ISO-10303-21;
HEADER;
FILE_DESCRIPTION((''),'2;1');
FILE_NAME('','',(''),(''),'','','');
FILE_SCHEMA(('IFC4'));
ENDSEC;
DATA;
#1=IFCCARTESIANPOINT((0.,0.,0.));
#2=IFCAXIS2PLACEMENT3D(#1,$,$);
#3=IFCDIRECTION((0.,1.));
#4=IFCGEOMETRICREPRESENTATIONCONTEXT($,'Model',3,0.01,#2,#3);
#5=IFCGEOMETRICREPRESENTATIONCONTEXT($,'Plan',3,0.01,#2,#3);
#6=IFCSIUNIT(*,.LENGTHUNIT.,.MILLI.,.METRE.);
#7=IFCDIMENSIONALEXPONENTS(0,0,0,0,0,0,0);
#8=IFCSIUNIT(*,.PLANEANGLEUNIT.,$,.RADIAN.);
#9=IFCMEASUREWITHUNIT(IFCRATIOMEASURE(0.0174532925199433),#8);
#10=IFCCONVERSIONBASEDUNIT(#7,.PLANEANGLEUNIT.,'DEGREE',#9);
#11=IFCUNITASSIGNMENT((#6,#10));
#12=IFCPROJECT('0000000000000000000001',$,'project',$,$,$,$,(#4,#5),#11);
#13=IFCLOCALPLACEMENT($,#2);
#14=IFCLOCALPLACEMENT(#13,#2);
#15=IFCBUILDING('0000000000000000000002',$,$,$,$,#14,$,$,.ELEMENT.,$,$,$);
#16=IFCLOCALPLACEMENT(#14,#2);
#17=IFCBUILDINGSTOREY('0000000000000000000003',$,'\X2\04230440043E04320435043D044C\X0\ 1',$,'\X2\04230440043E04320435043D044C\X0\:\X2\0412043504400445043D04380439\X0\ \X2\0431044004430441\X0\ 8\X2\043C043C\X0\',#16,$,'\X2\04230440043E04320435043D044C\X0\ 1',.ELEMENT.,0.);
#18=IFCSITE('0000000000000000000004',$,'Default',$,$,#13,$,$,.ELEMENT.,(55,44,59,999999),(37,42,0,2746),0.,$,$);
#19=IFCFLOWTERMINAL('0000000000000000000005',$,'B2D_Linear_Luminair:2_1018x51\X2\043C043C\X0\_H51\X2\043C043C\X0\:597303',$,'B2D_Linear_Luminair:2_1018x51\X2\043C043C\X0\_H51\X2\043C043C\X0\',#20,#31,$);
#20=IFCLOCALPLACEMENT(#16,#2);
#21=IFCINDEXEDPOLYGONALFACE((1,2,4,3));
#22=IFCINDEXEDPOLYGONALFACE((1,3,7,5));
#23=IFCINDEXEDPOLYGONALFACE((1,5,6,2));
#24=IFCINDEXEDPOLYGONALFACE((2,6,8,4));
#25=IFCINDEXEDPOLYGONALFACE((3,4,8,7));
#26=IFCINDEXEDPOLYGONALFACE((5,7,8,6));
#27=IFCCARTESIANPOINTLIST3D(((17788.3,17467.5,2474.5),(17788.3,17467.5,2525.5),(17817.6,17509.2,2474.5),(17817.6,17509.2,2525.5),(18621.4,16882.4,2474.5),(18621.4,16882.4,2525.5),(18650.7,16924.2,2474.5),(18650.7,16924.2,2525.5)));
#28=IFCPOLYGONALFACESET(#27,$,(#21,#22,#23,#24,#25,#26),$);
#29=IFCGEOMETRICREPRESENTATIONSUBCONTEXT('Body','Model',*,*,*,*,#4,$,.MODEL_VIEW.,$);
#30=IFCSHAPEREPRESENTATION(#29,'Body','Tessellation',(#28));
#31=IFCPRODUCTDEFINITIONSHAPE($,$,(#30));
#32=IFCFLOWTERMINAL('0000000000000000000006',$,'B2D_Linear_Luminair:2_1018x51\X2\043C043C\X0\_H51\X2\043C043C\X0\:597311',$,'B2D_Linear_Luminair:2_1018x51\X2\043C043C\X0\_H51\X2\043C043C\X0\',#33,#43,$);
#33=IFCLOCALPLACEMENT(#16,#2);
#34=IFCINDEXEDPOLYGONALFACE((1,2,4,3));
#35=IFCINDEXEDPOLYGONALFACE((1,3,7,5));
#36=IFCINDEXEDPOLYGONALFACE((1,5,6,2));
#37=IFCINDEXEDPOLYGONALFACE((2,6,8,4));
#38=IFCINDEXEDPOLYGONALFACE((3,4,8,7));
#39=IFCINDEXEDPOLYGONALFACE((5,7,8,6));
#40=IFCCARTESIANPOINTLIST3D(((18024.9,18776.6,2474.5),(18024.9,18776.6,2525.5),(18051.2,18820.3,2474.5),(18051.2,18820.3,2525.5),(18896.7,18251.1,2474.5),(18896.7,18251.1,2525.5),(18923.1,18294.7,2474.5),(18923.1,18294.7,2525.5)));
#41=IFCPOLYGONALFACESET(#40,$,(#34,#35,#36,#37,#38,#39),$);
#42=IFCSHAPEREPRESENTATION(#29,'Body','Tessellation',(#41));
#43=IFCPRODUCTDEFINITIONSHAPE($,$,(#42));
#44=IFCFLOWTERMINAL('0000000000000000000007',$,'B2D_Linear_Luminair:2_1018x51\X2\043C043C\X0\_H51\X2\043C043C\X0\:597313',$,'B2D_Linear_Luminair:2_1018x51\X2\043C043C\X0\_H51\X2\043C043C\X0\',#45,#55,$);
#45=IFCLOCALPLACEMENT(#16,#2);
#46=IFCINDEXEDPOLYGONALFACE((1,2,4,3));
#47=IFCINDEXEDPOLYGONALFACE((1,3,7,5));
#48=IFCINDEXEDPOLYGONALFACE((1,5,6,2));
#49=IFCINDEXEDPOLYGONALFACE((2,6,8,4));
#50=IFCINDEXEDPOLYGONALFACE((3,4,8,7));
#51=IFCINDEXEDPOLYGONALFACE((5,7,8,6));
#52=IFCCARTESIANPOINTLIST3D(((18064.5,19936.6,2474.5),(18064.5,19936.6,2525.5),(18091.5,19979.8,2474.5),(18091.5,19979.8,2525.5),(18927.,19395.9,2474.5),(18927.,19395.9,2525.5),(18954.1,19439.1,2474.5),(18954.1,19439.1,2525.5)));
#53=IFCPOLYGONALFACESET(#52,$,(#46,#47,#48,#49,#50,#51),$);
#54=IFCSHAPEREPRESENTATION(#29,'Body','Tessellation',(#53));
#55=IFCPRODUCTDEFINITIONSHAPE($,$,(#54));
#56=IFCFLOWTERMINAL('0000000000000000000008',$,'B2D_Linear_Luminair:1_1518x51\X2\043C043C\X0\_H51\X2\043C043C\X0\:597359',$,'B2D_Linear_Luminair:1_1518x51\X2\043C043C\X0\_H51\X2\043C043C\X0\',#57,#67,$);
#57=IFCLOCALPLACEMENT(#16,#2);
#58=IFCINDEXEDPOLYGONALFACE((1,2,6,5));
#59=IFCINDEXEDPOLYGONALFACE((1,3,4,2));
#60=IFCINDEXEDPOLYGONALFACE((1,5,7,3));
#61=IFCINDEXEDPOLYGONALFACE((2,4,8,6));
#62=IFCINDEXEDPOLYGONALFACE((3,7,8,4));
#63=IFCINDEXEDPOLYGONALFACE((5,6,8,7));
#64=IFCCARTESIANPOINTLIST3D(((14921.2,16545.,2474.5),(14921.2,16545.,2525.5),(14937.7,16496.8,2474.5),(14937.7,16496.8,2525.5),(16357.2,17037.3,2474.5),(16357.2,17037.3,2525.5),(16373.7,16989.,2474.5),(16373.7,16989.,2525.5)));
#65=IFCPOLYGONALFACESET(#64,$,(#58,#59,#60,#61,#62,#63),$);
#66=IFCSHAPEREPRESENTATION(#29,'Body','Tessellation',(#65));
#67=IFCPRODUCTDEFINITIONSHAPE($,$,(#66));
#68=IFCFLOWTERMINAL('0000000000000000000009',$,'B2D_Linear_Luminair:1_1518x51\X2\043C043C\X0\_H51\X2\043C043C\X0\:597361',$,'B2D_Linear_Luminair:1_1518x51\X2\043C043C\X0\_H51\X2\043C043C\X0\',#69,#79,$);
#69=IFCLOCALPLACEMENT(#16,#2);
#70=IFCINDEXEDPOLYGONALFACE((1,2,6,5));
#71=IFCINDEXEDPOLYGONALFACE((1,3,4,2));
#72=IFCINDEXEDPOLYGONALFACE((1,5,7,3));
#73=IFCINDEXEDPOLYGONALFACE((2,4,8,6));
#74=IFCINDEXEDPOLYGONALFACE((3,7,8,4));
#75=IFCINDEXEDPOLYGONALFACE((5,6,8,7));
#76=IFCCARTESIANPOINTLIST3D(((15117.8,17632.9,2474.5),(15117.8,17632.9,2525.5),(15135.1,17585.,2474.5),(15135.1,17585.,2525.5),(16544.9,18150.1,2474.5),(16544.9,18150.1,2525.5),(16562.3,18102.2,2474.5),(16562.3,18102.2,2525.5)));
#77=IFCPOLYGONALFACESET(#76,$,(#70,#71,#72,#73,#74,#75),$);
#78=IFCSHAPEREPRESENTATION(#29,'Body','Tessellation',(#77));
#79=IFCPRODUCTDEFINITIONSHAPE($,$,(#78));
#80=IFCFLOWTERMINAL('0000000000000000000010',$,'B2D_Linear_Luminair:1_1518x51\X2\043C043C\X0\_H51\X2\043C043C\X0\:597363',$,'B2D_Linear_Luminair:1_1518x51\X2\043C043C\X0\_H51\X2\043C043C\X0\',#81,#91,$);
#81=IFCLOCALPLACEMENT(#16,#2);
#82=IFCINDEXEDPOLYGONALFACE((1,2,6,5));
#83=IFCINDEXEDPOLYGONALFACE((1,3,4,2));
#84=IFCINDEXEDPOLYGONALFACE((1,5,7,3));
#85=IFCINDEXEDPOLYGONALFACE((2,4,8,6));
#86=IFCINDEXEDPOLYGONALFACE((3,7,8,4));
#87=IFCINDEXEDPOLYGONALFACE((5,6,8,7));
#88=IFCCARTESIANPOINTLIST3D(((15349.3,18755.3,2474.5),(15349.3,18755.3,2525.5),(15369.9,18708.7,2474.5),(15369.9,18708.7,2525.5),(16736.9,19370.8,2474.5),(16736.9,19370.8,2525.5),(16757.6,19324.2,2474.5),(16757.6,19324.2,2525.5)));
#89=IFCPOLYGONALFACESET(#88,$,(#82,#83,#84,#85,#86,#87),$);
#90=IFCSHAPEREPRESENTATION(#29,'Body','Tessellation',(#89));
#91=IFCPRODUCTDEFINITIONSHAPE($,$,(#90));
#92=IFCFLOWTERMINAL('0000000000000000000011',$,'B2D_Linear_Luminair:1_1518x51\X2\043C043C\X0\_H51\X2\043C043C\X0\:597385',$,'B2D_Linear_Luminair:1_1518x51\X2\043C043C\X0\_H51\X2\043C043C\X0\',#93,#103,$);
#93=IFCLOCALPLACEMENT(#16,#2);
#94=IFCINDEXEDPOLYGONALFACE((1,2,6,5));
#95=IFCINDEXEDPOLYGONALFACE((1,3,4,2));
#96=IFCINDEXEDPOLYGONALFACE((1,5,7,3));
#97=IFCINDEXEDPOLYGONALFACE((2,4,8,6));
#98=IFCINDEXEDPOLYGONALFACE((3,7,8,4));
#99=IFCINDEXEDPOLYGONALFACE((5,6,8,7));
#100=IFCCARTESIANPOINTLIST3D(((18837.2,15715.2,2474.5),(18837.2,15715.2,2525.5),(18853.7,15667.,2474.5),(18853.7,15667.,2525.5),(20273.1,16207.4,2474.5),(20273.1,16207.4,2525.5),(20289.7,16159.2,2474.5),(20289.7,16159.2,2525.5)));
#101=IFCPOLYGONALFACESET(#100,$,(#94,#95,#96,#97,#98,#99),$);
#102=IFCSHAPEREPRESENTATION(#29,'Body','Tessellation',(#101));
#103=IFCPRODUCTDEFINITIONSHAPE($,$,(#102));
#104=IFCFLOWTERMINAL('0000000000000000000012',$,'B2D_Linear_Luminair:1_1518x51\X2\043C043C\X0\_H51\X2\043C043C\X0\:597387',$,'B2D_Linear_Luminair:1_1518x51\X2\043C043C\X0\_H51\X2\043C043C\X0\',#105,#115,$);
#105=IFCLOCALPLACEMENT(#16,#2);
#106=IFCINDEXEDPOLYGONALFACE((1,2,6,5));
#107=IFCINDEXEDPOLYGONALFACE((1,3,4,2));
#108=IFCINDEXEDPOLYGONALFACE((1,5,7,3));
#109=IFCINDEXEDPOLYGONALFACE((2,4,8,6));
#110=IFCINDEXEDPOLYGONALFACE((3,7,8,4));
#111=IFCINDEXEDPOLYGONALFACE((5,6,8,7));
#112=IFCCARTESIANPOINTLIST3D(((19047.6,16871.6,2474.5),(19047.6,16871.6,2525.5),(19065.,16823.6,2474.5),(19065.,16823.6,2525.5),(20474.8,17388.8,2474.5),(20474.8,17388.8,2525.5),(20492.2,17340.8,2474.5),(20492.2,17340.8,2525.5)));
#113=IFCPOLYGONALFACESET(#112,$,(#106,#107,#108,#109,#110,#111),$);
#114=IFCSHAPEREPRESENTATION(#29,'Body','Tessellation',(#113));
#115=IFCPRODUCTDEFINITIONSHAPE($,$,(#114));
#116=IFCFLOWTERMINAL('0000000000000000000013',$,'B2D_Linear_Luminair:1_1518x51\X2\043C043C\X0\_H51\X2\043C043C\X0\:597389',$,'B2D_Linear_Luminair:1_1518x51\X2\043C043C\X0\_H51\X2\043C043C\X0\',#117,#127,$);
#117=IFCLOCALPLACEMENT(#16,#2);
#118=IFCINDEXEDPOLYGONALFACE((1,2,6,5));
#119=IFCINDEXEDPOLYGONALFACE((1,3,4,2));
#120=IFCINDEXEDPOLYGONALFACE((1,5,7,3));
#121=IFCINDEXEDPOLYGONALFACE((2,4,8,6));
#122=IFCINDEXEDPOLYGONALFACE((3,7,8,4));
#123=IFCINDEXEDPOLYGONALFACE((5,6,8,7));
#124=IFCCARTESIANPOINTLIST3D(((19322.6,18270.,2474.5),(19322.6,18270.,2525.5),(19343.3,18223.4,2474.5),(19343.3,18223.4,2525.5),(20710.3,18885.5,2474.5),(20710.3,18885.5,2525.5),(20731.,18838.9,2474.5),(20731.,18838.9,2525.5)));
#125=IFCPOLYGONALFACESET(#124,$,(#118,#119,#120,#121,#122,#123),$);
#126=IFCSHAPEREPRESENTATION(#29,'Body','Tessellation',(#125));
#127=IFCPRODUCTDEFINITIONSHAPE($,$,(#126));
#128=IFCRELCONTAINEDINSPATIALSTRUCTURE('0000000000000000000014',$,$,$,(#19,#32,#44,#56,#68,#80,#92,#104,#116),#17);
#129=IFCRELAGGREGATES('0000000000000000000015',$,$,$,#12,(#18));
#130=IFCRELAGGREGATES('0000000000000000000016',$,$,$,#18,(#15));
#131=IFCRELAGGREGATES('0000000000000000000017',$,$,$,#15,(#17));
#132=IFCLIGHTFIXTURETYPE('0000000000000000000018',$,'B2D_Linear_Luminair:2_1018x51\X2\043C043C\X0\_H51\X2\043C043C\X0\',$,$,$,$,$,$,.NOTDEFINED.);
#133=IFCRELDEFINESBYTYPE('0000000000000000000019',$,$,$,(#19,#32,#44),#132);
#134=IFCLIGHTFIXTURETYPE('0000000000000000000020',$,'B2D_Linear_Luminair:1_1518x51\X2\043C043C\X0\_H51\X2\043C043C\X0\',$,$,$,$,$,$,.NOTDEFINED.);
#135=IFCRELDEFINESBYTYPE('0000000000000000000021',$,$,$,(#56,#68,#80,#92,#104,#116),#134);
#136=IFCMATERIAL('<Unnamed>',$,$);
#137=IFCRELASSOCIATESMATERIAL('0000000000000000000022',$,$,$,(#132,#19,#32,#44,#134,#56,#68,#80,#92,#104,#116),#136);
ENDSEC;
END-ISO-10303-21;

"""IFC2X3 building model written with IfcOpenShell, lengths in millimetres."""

from ifc_helpers import new_model, entity, si_unit, converted_unit, direction, frame, origin, origin_2d_with_axis, place, context, subcontext, project, spatial, rectangle, extrude, source, transform, mapped, material, type_object, type_shapes, element, save


model = new_model("IFC2X3")

# Units and contexts
model_context = context("Model", 3, precision=0.01, world=origin(), true_north=direction((0.0, 1.0)))
plan_context = context("Plan", 3, precision=0.01, world=origin(), true_north=direction((0.0, 1.0)))
body_context = subcontext(model_context, "Body", "Model", "MODEL_VIEW")
ifc_project = project(units=[si_unit("LENGTHUNIT", "METRE", prefix="MILLI"), converted_unit("PLANEANGLEUNIT", "DEGREE", entity("IfcRatioMeasure", 0.0174532925199433), si_unit("PLANEANGLEUNIT", "RADIAN"), dimensions=[0, 0, 0, 0, 0, 0, 0])], contexts=[model_context, plan_context])

# Site, building, storey
site_placement = place(None, origin())
site = spatial("IfcSite", under=ifc_project, at=site_placement, Name="Default", CompositionType="ELEMENT", RefLatitude=(55, 44, 59, 999999), RefLongitude=(37, 42, 0, 2746), RefElevation=0.0)
building_placement = place(site_placement, origin())
building = spatial("IfcBuilding", under=site, at=building_placement, CompositionType="ELEMENT")
storey_placement = place(building_placement, origin())
storey = spatial("IfcBuildingStorey", under=building, at=storey_placement, Name="Уровень 1", ObjectType="Уровень:Верхний брус 8мм", LongName="Уровень 1", CompositionType="ELEMENT", Elevation=0.0)

# Flow terminals
ifc_material = material(Name="<Unnamed>")
light_fixture_type_1 = type_object("IfcLightFixtureType", Name="B2D_Linear_Luminair:2_1018x51мм_H51мм", PredefinedType="NOTDEFINED", material=ifc_material)
shared_shape_1 = source(origin(), body_context, "Body", "SweptSolid", [
    extrude(rectangle(XDim=1018.0, YDim=51.0, at=origin_2d_with_axis()), frame((0.0, 0.0, 0.0), z_axis=(0.0, 0.0, 1.0), x_axis=(-1.0, 0.0, 0.0)), (0.0, 0.0, 1.0), 51.0),
])
type_shapes(light_fixture_type_1, [shared_shape_1])
for number, where, z_axis, x_axis, name in (
    (1, (18219.5, 17195.8, 2525.5), (0.0, 0.0, -1.0), (0.81835, -0.57472, 0.0), "B2D_Linear_Luminair:2_1018x51мм_H51мм:597303"),
    (2, (18474.0, 18535.7, 2525.5), (0.0, 0.0, -1.0), (0.856447, -0.516234, 0.0), "B2D_Linear_Luminair:2_1018x51мм_H51мм:597311"),
    (3, (18509.3, 19687.9, 2525.5), (0.0, 0.0, -1.0), (0.847307, -0.531103, 0.0), "B2D_Linear_Luminair:2_1018x51мм_H51мм:597313"),
):
    element("IfcFlowTerminal", number, at=place(storey_placement, frame(where, z_axis=z_axis, x_axis=x_axis)), inside=storey, type_object=light_fixture_type_1, material=ifc_material, Name=name, ObjectType="B2D_Linear_Luminair:2_1018x51мм_H51мм", context=body_context, shape_type="MappedRepresentation", body=[
        mapped(shared_shape_1, transform((0.0, 0.0, 0.0), scale=1.0)),
    ])
light_fixture_type_2 = type_object("IfcLightFixtureType", Name="B2D_Linear_Luminair:1_1518x51мм_H51мм", PredefinedType="NOTDEFINED", material=ifc_material)
shared_shape_2 = source(origin(), body_context, "Body", "SweptSolid", [
    extrude(rectangle(XDim=1518.0, YDim=51.0, at=origin_2d_with_axis()), frame((0.0, 0.0, 0.0), z_axis=(0.0, 0.0, 1.0), x_axis=(-1.0, 0.0, 0.0)), (0.0, 0.0, 1.0), 51.0),
])
type_shapes(light_fixture_type_2, [shared_shape_2])
for number, where, z_axis, x_axis, name in (
    (4, (15647.5, 16767.0, 2525.5), (0.0, 0.0, -1.0), (0.945972, 0.324248, 0.0), "B2D_Linear_Luminair:1_1518x51мм_H51мм:597359"),
    (5, (15840.0, 17867.6, 2525.5), (0.0, 0.0, -1.0), (0.940169, 0.340708, 0.0), "B2D_Linear_Luminair:1_1518x51мм_H51мм:597361"),
    (6, (16053.4, 19039.8, 2525.5), (0.0, 0.0, -1.0), (0.914112, 0.405461, 0.0), "B2D_Linear_Luminair:1_1518x51мм_H51мм:597363"),
    (7, (19563.4, 15937.2, 2525.5), (0.0, 0.0, -1.0), (0.945972, 0.324248, 0.0), "B2D_Linear_Luminair:1_1518x51мм_H51мм:597385"),
    (8, (19769.9, 17106.2, 2525.5), (0.0, 0.0, -1.0), (0.940169, 0.340708, 0.0), "B2D_Linear_Luminair:1_1518x51мм_H51мм:597387"),
    (9, (20026.8, 18554.4, 2525.5), (0.0, 0.0, -1.0), (0.914112, 0.405461, 0.0), "B2D_Linear_Luminair:1_1518x51мм_H51мм:597389"),
):
    element("IfcFlowTerminal", number, at=place(storey_placement, frame(where, z_axis=z_axis, x_axis=x_axis)), inside=storey, type_object=light_fixture_type_2, material=ifc_material, Name=name, ObjectType="B2D_Linear_Luminair:1_1518x51мм_H51мм", context=body_context, shape_type="MappedRepresentation", body=[
        mapped(shared_shape_2, transform((0.0, 0.0, 0.0), scale=1.0)),
    ])

save(model, "model.ifc")
